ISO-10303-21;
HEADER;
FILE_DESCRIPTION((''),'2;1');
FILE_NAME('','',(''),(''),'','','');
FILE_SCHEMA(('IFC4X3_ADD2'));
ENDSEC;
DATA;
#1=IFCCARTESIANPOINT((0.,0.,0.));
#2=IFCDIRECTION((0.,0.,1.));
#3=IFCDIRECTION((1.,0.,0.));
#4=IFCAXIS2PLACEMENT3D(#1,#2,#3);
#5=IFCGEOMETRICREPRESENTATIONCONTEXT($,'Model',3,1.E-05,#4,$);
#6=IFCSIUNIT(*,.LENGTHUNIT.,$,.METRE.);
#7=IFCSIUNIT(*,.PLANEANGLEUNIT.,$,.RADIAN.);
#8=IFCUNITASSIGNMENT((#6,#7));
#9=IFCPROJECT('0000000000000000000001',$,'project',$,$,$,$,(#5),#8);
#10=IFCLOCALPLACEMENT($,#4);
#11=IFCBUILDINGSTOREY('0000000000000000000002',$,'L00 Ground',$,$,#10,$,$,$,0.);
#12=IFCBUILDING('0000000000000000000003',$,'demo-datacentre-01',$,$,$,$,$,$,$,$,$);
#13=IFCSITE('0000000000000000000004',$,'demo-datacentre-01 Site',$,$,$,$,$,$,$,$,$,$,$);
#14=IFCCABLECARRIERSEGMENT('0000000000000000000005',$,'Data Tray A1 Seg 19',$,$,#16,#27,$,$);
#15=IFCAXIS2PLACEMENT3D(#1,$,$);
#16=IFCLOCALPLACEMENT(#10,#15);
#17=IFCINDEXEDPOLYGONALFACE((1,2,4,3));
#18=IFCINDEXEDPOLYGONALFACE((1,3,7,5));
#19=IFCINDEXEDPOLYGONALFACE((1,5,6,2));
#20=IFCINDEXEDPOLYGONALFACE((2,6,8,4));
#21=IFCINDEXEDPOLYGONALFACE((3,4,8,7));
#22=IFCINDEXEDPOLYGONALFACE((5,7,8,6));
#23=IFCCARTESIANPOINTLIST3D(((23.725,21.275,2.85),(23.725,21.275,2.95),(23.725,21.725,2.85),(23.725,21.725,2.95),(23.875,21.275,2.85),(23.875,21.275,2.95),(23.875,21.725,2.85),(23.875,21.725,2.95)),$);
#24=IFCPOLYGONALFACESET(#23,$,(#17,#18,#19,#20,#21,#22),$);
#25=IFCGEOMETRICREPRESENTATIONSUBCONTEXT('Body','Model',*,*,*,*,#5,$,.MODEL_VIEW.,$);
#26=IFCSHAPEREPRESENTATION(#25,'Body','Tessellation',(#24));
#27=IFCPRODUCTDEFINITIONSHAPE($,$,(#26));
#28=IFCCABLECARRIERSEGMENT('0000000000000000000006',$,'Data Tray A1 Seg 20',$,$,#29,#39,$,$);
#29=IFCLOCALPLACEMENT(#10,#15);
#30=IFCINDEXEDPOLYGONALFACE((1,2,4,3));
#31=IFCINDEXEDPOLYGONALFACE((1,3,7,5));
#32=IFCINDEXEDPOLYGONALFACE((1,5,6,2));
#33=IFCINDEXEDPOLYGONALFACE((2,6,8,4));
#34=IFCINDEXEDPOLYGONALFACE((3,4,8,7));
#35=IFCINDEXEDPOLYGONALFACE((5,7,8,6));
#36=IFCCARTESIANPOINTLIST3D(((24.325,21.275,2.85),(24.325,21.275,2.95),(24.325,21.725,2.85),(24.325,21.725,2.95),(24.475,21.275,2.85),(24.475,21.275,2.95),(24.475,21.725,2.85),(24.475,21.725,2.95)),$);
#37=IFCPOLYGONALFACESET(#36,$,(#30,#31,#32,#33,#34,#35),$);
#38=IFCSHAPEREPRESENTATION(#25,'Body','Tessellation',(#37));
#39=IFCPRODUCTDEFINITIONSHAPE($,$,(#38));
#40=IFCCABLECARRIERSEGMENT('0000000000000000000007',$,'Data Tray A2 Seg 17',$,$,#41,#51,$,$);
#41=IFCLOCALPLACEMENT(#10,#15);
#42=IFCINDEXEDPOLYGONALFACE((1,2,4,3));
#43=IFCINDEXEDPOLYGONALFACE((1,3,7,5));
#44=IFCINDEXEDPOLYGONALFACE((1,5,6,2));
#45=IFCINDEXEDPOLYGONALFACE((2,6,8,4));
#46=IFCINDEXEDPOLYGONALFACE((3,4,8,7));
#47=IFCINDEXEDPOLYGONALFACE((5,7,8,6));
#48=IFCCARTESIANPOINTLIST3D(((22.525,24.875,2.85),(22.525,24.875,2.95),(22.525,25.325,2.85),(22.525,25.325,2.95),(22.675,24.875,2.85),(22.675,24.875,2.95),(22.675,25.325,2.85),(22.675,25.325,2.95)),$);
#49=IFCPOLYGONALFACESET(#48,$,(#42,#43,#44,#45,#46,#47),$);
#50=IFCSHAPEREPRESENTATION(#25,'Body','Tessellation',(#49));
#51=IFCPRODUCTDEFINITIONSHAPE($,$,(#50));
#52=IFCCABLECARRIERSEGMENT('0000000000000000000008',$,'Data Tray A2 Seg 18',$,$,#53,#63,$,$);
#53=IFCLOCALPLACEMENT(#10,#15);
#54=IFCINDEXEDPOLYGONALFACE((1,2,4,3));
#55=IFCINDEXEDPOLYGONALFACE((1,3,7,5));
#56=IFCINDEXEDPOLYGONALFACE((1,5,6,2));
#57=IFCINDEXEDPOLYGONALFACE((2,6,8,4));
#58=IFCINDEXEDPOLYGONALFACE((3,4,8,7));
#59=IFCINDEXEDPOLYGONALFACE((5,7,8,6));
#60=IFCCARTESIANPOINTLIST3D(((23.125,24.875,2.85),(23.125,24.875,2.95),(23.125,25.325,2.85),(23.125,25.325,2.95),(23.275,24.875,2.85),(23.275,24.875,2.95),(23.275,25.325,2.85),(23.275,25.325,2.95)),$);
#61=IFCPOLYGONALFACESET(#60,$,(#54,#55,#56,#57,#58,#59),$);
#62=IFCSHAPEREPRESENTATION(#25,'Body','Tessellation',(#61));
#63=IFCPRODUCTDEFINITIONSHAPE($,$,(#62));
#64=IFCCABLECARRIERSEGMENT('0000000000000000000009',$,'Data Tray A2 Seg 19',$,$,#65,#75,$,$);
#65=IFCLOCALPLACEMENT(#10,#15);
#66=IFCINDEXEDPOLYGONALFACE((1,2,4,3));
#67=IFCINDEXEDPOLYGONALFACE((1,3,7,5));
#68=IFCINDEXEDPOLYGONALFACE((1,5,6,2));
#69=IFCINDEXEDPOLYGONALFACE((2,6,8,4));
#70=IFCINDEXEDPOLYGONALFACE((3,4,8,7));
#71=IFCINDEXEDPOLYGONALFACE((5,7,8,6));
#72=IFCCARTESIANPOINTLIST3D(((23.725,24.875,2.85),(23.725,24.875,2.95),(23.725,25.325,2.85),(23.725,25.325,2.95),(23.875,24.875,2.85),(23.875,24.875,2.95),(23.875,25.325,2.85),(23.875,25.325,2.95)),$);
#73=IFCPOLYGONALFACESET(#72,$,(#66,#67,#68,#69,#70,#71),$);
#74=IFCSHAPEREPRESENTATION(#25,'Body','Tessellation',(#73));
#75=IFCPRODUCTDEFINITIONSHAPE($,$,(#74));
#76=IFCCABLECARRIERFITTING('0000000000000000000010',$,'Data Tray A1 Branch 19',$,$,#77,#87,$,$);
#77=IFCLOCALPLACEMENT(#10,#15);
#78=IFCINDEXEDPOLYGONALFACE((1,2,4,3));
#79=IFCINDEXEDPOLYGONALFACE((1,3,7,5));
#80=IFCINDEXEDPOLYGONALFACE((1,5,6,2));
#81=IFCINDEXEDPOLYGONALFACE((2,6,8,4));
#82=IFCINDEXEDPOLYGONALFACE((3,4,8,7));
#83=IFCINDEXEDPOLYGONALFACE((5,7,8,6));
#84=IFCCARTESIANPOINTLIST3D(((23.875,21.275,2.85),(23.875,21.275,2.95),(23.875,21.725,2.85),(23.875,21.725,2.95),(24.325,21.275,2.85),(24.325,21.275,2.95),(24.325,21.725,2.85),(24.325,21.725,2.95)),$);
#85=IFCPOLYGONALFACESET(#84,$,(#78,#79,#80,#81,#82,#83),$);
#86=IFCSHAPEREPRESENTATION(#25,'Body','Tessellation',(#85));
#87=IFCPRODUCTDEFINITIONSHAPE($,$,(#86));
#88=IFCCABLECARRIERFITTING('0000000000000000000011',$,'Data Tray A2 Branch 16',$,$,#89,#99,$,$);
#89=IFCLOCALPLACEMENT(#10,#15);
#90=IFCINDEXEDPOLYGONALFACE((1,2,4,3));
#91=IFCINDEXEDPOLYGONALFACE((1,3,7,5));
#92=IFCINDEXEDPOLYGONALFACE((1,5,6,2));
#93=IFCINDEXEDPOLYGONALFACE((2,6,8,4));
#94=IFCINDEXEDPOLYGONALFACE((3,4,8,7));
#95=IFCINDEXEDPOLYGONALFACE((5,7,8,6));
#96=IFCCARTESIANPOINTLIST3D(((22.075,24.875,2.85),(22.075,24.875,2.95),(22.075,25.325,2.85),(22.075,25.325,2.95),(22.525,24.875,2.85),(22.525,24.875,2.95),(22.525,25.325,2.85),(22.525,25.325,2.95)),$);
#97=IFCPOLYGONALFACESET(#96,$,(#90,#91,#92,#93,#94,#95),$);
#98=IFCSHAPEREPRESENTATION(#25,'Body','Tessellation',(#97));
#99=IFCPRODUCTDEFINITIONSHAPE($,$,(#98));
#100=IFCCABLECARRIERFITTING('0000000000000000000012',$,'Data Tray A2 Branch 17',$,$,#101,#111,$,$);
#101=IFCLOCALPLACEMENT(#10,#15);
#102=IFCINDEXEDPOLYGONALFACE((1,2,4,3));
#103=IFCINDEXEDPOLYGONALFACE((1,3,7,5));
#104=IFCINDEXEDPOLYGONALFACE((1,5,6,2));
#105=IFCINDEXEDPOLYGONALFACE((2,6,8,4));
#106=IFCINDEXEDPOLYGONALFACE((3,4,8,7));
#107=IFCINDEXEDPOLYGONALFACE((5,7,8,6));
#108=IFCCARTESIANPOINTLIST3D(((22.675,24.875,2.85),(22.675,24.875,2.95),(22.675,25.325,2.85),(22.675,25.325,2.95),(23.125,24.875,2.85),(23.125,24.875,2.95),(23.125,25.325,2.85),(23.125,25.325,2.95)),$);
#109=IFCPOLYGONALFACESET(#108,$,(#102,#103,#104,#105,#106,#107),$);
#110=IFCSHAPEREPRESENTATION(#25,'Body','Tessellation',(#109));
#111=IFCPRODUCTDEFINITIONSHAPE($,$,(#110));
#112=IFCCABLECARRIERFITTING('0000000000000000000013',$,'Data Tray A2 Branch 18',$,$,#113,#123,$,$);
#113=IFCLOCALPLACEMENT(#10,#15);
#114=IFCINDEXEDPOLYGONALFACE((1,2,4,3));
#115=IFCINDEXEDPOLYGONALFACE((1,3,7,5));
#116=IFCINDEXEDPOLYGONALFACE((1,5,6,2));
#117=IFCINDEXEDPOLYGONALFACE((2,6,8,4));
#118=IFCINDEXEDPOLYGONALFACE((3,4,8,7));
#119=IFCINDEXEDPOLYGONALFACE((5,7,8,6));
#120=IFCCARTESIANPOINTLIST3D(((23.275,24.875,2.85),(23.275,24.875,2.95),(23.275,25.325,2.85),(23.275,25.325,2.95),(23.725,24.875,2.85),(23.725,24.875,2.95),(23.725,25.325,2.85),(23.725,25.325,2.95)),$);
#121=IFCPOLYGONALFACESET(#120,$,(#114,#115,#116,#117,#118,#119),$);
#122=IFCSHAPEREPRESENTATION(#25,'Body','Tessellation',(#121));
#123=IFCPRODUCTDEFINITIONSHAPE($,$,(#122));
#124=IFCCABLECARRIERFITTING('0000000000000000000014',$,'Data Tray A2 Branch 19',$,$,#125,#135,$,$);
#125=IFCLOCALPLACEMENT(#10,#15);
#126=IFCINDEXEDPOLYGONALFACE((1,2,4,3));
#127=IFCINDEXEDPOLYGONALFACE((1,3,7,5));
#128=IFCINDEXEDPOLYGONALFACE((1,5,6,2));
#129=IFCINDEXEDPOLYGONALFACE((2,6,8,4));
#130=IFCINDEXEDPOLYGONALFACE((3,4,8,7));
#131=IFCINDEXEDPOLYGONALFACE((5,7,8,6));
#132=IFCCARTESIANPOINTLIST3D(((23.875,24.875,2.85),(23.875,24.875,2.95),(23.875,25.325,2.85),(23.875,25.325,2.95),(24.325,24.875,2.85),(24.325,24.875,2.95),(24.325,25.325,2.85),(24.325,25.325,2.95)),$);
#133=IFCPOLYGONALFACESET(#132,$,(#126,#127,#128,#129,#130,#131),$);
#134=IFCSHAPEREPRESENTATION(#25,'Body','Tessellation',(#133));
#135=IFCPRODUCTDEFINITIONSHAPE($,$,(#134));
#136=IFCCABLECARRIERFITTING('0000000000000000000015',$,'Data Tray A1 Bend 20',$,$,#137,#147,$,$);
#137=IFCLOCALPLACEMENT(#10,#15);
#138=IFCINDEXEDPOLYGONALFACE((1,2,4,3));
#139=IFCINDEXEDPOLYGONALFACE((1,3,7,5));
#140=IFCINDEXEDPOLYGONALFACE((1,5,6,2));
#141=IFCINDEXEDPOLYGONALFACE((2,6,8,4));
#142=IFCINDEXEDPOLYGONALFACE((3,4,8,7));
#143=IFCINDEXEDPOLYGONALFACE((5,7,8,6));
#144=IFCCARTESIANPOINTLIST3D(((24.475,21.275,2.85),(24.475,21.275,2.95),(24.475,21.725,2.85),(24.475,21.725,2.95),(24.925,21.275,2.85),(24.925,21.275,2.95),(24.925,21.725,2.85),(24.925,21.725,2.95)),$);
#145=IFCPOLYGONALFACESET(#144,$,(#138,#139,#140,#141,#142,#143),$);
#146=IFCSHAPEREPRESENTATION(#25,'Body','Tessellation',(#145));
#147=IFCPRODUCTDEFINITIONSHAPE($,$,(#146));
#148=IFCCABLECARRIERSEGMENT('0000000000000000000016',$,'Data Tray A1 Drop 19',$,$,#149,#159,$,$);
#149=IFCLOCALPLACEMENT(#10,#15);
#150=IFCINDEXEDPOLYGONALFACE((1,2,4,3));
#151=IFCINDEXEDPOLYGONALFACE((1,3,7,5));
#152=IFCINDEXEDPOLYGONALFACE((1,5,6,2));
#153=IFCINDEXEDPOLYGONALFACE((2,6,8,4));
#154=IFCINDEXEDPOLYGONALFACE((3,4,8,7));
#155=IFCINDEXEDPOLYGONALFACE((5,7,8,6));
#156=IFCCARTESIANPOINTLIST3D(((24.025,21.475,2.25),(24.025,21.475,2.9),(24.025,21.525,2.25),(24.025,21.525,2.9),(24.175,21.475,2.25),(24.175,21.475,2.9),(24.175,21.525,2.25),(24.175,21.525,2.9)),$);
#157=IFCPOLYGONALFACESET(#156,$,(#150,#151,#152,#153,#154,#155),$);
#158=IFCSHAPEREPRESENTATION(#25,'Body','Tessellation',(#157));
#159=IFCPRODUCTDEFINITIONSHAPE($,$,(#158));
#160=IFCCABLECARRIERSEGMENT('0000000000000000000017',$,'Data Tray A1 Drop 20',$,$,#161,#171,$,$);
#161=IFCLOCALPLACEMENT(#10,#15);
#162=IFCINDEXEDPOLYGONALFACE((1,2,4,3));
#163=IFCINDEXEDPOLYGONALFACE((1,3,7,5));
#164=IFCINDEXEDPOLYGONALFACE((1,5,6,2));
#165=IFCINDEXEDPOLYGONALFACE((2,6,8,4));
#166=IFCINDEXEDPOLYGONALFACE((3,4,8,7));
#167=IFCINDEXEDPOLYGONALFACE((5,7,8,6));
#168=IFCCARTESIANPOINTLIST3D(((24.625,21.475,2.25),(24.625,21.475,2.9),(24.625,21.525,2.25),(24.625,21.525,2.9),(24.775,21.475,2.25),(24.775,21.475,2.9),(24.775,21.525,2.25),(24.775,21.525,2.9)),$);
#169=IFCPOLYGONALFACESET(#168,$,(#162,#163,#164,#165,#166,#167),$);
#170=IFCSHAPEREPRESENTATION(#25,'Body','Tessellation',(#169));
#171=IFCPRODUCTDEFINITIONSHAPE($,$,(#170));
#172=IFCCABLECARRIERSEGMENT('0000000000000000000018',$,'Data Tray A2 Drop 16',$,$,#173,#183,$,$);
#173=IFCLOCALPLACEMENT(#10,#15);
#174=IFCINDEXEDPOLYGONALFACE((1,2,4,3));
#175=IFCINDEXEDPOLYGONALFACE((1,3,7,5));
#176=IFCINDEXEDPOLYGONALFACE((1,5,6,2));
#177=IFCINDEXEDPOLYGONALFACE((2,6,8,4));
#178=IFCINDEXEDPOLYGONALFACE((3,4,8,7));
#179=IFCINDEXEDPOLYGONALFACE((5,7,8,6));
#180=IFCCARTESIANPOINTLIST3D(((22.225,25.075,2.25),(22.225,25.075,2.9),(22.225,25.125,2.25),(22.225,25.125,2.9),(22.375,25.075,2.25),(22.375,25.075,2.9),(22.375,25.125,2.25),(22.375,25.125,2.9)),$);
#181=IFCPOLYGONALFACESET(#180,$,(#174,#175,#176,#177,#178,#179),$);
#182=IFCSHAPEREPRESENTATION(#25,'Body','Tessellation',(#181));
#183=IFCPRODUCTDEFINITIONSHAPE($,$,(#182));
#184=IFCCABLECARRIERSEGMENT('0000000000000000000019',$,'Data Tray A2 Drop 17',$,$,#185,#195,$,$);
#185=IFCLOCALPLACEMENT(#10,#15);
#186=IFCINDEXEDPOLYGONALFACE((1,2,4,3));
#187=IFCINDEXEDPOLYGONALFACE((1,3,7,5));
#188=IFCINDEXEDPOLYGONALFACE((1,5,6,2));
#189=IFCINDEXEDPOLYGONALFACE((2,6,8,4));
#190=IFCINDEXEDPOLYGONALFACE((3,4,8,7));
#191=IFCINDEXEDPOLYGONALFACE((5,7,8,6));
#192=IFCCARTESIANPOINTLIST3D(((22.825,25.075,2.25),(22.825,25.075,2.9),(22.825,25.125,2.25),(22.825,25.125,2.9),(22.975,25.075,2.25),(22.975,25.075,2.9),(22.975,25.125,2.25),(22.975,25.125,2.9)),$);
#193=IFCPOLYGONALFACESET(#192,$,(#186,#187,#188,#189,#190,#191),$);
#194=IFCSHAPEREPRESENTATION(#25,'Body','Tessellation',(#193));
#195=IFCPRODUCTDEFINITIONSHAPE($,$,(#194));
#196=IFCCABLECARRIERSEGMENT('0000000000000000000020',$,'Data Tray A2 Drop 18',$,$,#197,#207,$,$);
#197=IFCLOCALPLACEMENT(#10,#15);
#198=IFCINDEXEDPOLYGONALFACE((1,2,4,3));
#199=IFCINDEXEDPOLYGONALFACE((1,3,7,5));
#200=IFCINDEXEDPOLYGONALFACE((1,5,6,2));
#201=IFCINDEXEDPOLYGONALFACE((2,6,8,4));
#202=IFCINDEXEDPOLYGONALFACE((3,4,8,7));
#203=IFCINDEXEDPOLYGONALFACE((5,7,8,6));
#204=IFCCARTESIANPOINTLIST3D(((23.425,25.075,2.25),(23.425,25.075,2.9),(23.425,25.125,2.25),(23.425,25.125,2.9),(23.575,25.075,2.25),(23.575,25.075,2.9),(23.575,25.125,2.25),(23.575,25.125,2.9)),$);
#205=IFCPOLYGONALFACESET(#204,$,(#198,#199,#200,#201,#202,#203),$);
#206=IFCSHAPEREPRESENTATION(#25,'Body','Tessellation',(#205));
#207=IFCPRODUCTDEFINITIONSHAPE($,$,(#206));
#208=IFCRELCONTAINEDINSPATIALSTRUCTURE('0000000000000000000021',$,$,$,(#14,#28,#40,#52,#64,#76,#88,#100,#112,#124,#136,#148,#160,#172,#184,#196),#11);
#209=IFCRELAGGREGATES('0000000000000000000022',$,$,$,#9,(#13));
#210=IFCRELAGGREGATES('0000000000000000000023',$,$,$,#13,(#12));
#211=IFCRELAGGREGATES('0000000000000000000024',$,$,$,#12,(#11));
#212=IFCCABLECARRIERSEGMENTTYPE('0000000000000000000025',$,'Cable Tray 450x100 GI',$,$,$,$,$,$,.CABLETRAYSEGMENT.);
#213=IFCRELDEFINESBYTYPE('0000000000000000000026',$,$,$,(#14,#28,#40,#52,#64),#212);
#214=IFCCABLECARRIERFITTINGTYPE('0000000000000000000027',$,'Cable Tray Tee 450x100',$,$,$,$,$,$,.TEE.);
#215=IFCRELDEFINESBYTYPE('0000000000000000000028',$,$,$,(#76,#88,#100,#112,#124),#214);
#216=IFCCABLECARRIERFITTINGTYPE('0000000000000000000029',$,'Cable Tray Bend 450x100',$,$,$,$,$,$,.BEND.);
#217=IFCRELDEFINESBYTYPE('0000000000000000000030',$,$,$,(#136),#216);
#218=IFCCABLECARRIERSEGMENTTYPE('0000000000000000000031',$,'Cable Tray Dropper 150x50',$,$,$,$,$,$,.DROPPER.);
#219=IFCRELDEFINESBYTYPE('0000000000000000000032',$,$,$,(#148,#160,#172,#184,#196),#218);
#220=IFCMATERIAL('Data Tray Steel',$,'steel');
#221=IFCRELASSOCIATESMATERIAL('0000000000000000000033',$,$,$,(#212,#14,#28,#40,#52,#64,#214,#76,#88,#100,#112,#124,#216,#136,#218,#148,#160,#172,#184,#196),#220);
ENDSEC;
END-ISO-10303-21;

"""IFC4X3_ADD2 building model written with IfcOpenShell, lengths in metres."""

from ifc_helpers import new_model, si_unit, frame, origin_with_axes, place, context, subcontext, project, spatial, rectangle, extrude, material, type_object, element, save


model = new_model("IFC4X3_ADD2")

# Units and contexts
model_context = context("Model", 3, precision=1e-05, world=origin_with_axes())
body_context = subcontext(model_context, "Body", "Model", "MODEL_VIEW")
ifc_project = project(units=[si_unit("LENGTHUNIT", "METRE"), si_unit("PLANEANGLEUNIT", "RADIAN")], contexts=[model_context])

# Site, building, storey
site = spatial("IfcSite", under=ifc_project, Name="demo-datacentre-01 Site")
building = spatial("IfcBuilding", under=site, Name="demo-datacentre-01")
storey_placement = place(None, origin_with_axes())
storey = spatial("IfcBuildingStorey", under=building, at=storey_placement, Name="L00 Ground", Elevation=0.0)

# Cable carrier segments
ifc_material_1 = material(Name="Data Tray Steel", Category="steel")
cable_carrier_segment_type_1 = type_object("IfcCableCarrierSegmentType", Name="Cable Tray 450x100 GI", PredefinedType="CABLETRAYSEGMENT", material=ifc_material_1)
for number, where, z_axis, x_axis, name in (
    (1, (23.725, 21.5, 2.9), (1.0, 0.0, 0.0), (0.0, 1.0, 0.0), "Data Tray A1 Seg 19"),
    (2, (24.325, 21.5, 2.9), (1.0, 0.0, 0.0), (0.0, 1.0, 0.0), "Data Tray A1 Seg 20"),
):
    element("IfcCableCarrierSegment", number, at=place(storey_placement, frame(where, z_axis=z_axis, x_axis=x_axis)), inside=storey, type_object=cable_carrier_segment_type_1, material=ifc_material_1, Name=name, context=body_context, shape_type="SweptSolid", body=[
        extrude(rectangle(XDim=0.45, YDim=0.1), origin_with_axes(), (0.0, 0.0, 1.0), 0.15),
    ])
cable_carrier_segment_placement = place(storey_placement, frame((22.525, 25.1, 2.9), z_axis=(1.0, 0.0, 0.0), x_axis=(0.0, 1.0, 0.0)))
element("IfcCableCarrierSegment", 3, at=cable_carrier_segment_placement, inside=storey, type_object=cable_carrier_segment_type_1, material=ifc_material_1, Name="Data Tray A2 Seg 17", context=body_context, shape_type="SweptSolid", body=[
    extrude(rectangle(XDim=0.45, YDim=0.1), origin_with_axes(), (0.0, 0.0, 1.0), 0.15),
])
for number, where, z_axis, x_axis, name in (
    (4, (23.125, 25.1, 2.9), (1.0, 0.0, 0.0), (0.0, 1.0, 0.0), "Data Tray A2 Seg 18"),
    (5, (23.725, 25.1, 2.9), (1.0, 0.0, 0.0), (0.0, 1.0, 0.0), "Data Tray A2 Seg 19"),
):
    element("IfcCableCarrierSegment", number, at=place(storey_placement, frame(where, z_axis=z_axis, x_axis=x_axis)), inside=storey, type_object=cable_carrier_segment_type_1, material=ifc_material_1, Name=name, context=body_context, shape_type="SweptSolid", body=[
        extrude(rectangle(XDim=0.45, YDim=0.1), origin_with_axes(), (0.0, 0.0, 1.0), 0.15),
    ])

# Cable carrier fittings
cable_carrier_fitting_type_1 = type_object("IfcCableCarrierFittingType", Name="Cable Tray Tee 450x100", PredefinedType="TEE", material=ifc_material_1)
for number, where, z_axis, x_axis, name in (
    (6, (24.1, 21.5, 2.85), (0.0, 0.0, 1.0), (1.0, 0.0, 0.0), "Data Tray A1 Branch 19"),
    (7, (22.3, 25.1, 2.85), (0.0, 0.0, 1.0), (1.0, 0.0, 0.0), "Data Tray A2 Branch 16"),
    (8, (22.9, 25.1, 2.85), (0.0, 0.0, 1.0), (1.0, 0.0, 0.0), "Data Tray A2 Branch 17"),
    (9, (23.5, 25.1, 2.85), (0.0, 0.0, 1.0), (1.0, 0.0, 0.0), "Data Tray A2 Branch 18"),
    (10, (24.1, 25.1, 2.85), (0.0, 0.0, 1.0), (1.0, 0.0, 0.0), "Data Tray A2 Branch 19"),
):
    element("IfcCableCarrierFitting", number, at=place(storey_placement, frame(where, z_axis=z_axis, x_axis=x_axis)), inside=storey, type_object=cable_carrier_fitting_type_1, material=ifc_material_1, Name=name, context=body_context, shape_type="SweptSolid", body=[
        extrude(rectangle(XDim=0.45, YDim=0.45), origin_with_axes(), (0.0, 0.0, 1.0), 0.1),
    ])
cable_carrier_fitting_type_2 = type_object("IfcCableCarrierFittingType", Name="Cable Tray Bend 450x100", PredefinedType="BEND", material=ifc_material_1)
cable_carrier_fitting_placement = place(storey_placement, frame((24.7, 21.5, 2.85), z_axis=(0.0, 0.0, 1.0), x_axis=(1.0, 0.0, 0.0)))
element("IfcCableCarrierFitting", 11, at=cable_carrier_fitting_placement, inside=storey, type_object=cable_carrier_fitting_type_2, material=ifc_material_1, Name="Data Tray A1 Bend 20", context=body_context, shape_type="SweptSolid", body=[
    extrude(rectangle(XDim=0.45, YDim=0.45), origin_with_axes(), (0.0, 0.0, 1.0), 0.1),
])

# Cable carrier segments
cable_carrier_segment_type_2 = type_object("IfcCableCarrierSegmentType", Name="Cable Tray Dropper 150x50", PredefinedType="DROPPER", material=ifc_material_1)
for number, where, z_axis, x_axis, name in (
    (12, (24.1, 21.5, 2.9), (0.0, 0.0, -1.0), (1.0, 0.0, 0.0), "Data Tray A1 Drop 19"),
    (13, (24.7, 21.5, 2.9), (0.0, 0.0, -1.0), (1.0, 0.0, 0.0), "Data Tray A1 Drop 20"),
    (14, (22.3, 25.1, 2.9), (0.0, 0.0, -1.0), (1.0, 0.0, 0.0), "Data Tray A2 Drop 16"),
    (15, (22.9, 25.1, 2.9), (0.0, 0.0, -1.0), (1.0, 0.0, 0.0), "Data Tray A2 Drop 17"),
    (16, (23.5, 25.1, 2.9), (0.0, 0.0, -1.0), (1.0, 0.0, 0.0), "Data Tray A2 Drop 18"),
):
    element("IfcCableCarrierSegment", number, at=place(storey_placement, frame(where, z_axis=z_axis, x_axis=x_axis)), inside=storey, type_object=cable_carrier_segment_type_2, material=ifc_material_1, Name=name, context=body_context, shape_type="SweptSolid", body=[
        extrude(rectangle(XDim=0.15, YDim=0.05), origin_with_axes(), (0.0, 0.0, 1.0), 0.65),
    ])

save(model, "model.ifc")
